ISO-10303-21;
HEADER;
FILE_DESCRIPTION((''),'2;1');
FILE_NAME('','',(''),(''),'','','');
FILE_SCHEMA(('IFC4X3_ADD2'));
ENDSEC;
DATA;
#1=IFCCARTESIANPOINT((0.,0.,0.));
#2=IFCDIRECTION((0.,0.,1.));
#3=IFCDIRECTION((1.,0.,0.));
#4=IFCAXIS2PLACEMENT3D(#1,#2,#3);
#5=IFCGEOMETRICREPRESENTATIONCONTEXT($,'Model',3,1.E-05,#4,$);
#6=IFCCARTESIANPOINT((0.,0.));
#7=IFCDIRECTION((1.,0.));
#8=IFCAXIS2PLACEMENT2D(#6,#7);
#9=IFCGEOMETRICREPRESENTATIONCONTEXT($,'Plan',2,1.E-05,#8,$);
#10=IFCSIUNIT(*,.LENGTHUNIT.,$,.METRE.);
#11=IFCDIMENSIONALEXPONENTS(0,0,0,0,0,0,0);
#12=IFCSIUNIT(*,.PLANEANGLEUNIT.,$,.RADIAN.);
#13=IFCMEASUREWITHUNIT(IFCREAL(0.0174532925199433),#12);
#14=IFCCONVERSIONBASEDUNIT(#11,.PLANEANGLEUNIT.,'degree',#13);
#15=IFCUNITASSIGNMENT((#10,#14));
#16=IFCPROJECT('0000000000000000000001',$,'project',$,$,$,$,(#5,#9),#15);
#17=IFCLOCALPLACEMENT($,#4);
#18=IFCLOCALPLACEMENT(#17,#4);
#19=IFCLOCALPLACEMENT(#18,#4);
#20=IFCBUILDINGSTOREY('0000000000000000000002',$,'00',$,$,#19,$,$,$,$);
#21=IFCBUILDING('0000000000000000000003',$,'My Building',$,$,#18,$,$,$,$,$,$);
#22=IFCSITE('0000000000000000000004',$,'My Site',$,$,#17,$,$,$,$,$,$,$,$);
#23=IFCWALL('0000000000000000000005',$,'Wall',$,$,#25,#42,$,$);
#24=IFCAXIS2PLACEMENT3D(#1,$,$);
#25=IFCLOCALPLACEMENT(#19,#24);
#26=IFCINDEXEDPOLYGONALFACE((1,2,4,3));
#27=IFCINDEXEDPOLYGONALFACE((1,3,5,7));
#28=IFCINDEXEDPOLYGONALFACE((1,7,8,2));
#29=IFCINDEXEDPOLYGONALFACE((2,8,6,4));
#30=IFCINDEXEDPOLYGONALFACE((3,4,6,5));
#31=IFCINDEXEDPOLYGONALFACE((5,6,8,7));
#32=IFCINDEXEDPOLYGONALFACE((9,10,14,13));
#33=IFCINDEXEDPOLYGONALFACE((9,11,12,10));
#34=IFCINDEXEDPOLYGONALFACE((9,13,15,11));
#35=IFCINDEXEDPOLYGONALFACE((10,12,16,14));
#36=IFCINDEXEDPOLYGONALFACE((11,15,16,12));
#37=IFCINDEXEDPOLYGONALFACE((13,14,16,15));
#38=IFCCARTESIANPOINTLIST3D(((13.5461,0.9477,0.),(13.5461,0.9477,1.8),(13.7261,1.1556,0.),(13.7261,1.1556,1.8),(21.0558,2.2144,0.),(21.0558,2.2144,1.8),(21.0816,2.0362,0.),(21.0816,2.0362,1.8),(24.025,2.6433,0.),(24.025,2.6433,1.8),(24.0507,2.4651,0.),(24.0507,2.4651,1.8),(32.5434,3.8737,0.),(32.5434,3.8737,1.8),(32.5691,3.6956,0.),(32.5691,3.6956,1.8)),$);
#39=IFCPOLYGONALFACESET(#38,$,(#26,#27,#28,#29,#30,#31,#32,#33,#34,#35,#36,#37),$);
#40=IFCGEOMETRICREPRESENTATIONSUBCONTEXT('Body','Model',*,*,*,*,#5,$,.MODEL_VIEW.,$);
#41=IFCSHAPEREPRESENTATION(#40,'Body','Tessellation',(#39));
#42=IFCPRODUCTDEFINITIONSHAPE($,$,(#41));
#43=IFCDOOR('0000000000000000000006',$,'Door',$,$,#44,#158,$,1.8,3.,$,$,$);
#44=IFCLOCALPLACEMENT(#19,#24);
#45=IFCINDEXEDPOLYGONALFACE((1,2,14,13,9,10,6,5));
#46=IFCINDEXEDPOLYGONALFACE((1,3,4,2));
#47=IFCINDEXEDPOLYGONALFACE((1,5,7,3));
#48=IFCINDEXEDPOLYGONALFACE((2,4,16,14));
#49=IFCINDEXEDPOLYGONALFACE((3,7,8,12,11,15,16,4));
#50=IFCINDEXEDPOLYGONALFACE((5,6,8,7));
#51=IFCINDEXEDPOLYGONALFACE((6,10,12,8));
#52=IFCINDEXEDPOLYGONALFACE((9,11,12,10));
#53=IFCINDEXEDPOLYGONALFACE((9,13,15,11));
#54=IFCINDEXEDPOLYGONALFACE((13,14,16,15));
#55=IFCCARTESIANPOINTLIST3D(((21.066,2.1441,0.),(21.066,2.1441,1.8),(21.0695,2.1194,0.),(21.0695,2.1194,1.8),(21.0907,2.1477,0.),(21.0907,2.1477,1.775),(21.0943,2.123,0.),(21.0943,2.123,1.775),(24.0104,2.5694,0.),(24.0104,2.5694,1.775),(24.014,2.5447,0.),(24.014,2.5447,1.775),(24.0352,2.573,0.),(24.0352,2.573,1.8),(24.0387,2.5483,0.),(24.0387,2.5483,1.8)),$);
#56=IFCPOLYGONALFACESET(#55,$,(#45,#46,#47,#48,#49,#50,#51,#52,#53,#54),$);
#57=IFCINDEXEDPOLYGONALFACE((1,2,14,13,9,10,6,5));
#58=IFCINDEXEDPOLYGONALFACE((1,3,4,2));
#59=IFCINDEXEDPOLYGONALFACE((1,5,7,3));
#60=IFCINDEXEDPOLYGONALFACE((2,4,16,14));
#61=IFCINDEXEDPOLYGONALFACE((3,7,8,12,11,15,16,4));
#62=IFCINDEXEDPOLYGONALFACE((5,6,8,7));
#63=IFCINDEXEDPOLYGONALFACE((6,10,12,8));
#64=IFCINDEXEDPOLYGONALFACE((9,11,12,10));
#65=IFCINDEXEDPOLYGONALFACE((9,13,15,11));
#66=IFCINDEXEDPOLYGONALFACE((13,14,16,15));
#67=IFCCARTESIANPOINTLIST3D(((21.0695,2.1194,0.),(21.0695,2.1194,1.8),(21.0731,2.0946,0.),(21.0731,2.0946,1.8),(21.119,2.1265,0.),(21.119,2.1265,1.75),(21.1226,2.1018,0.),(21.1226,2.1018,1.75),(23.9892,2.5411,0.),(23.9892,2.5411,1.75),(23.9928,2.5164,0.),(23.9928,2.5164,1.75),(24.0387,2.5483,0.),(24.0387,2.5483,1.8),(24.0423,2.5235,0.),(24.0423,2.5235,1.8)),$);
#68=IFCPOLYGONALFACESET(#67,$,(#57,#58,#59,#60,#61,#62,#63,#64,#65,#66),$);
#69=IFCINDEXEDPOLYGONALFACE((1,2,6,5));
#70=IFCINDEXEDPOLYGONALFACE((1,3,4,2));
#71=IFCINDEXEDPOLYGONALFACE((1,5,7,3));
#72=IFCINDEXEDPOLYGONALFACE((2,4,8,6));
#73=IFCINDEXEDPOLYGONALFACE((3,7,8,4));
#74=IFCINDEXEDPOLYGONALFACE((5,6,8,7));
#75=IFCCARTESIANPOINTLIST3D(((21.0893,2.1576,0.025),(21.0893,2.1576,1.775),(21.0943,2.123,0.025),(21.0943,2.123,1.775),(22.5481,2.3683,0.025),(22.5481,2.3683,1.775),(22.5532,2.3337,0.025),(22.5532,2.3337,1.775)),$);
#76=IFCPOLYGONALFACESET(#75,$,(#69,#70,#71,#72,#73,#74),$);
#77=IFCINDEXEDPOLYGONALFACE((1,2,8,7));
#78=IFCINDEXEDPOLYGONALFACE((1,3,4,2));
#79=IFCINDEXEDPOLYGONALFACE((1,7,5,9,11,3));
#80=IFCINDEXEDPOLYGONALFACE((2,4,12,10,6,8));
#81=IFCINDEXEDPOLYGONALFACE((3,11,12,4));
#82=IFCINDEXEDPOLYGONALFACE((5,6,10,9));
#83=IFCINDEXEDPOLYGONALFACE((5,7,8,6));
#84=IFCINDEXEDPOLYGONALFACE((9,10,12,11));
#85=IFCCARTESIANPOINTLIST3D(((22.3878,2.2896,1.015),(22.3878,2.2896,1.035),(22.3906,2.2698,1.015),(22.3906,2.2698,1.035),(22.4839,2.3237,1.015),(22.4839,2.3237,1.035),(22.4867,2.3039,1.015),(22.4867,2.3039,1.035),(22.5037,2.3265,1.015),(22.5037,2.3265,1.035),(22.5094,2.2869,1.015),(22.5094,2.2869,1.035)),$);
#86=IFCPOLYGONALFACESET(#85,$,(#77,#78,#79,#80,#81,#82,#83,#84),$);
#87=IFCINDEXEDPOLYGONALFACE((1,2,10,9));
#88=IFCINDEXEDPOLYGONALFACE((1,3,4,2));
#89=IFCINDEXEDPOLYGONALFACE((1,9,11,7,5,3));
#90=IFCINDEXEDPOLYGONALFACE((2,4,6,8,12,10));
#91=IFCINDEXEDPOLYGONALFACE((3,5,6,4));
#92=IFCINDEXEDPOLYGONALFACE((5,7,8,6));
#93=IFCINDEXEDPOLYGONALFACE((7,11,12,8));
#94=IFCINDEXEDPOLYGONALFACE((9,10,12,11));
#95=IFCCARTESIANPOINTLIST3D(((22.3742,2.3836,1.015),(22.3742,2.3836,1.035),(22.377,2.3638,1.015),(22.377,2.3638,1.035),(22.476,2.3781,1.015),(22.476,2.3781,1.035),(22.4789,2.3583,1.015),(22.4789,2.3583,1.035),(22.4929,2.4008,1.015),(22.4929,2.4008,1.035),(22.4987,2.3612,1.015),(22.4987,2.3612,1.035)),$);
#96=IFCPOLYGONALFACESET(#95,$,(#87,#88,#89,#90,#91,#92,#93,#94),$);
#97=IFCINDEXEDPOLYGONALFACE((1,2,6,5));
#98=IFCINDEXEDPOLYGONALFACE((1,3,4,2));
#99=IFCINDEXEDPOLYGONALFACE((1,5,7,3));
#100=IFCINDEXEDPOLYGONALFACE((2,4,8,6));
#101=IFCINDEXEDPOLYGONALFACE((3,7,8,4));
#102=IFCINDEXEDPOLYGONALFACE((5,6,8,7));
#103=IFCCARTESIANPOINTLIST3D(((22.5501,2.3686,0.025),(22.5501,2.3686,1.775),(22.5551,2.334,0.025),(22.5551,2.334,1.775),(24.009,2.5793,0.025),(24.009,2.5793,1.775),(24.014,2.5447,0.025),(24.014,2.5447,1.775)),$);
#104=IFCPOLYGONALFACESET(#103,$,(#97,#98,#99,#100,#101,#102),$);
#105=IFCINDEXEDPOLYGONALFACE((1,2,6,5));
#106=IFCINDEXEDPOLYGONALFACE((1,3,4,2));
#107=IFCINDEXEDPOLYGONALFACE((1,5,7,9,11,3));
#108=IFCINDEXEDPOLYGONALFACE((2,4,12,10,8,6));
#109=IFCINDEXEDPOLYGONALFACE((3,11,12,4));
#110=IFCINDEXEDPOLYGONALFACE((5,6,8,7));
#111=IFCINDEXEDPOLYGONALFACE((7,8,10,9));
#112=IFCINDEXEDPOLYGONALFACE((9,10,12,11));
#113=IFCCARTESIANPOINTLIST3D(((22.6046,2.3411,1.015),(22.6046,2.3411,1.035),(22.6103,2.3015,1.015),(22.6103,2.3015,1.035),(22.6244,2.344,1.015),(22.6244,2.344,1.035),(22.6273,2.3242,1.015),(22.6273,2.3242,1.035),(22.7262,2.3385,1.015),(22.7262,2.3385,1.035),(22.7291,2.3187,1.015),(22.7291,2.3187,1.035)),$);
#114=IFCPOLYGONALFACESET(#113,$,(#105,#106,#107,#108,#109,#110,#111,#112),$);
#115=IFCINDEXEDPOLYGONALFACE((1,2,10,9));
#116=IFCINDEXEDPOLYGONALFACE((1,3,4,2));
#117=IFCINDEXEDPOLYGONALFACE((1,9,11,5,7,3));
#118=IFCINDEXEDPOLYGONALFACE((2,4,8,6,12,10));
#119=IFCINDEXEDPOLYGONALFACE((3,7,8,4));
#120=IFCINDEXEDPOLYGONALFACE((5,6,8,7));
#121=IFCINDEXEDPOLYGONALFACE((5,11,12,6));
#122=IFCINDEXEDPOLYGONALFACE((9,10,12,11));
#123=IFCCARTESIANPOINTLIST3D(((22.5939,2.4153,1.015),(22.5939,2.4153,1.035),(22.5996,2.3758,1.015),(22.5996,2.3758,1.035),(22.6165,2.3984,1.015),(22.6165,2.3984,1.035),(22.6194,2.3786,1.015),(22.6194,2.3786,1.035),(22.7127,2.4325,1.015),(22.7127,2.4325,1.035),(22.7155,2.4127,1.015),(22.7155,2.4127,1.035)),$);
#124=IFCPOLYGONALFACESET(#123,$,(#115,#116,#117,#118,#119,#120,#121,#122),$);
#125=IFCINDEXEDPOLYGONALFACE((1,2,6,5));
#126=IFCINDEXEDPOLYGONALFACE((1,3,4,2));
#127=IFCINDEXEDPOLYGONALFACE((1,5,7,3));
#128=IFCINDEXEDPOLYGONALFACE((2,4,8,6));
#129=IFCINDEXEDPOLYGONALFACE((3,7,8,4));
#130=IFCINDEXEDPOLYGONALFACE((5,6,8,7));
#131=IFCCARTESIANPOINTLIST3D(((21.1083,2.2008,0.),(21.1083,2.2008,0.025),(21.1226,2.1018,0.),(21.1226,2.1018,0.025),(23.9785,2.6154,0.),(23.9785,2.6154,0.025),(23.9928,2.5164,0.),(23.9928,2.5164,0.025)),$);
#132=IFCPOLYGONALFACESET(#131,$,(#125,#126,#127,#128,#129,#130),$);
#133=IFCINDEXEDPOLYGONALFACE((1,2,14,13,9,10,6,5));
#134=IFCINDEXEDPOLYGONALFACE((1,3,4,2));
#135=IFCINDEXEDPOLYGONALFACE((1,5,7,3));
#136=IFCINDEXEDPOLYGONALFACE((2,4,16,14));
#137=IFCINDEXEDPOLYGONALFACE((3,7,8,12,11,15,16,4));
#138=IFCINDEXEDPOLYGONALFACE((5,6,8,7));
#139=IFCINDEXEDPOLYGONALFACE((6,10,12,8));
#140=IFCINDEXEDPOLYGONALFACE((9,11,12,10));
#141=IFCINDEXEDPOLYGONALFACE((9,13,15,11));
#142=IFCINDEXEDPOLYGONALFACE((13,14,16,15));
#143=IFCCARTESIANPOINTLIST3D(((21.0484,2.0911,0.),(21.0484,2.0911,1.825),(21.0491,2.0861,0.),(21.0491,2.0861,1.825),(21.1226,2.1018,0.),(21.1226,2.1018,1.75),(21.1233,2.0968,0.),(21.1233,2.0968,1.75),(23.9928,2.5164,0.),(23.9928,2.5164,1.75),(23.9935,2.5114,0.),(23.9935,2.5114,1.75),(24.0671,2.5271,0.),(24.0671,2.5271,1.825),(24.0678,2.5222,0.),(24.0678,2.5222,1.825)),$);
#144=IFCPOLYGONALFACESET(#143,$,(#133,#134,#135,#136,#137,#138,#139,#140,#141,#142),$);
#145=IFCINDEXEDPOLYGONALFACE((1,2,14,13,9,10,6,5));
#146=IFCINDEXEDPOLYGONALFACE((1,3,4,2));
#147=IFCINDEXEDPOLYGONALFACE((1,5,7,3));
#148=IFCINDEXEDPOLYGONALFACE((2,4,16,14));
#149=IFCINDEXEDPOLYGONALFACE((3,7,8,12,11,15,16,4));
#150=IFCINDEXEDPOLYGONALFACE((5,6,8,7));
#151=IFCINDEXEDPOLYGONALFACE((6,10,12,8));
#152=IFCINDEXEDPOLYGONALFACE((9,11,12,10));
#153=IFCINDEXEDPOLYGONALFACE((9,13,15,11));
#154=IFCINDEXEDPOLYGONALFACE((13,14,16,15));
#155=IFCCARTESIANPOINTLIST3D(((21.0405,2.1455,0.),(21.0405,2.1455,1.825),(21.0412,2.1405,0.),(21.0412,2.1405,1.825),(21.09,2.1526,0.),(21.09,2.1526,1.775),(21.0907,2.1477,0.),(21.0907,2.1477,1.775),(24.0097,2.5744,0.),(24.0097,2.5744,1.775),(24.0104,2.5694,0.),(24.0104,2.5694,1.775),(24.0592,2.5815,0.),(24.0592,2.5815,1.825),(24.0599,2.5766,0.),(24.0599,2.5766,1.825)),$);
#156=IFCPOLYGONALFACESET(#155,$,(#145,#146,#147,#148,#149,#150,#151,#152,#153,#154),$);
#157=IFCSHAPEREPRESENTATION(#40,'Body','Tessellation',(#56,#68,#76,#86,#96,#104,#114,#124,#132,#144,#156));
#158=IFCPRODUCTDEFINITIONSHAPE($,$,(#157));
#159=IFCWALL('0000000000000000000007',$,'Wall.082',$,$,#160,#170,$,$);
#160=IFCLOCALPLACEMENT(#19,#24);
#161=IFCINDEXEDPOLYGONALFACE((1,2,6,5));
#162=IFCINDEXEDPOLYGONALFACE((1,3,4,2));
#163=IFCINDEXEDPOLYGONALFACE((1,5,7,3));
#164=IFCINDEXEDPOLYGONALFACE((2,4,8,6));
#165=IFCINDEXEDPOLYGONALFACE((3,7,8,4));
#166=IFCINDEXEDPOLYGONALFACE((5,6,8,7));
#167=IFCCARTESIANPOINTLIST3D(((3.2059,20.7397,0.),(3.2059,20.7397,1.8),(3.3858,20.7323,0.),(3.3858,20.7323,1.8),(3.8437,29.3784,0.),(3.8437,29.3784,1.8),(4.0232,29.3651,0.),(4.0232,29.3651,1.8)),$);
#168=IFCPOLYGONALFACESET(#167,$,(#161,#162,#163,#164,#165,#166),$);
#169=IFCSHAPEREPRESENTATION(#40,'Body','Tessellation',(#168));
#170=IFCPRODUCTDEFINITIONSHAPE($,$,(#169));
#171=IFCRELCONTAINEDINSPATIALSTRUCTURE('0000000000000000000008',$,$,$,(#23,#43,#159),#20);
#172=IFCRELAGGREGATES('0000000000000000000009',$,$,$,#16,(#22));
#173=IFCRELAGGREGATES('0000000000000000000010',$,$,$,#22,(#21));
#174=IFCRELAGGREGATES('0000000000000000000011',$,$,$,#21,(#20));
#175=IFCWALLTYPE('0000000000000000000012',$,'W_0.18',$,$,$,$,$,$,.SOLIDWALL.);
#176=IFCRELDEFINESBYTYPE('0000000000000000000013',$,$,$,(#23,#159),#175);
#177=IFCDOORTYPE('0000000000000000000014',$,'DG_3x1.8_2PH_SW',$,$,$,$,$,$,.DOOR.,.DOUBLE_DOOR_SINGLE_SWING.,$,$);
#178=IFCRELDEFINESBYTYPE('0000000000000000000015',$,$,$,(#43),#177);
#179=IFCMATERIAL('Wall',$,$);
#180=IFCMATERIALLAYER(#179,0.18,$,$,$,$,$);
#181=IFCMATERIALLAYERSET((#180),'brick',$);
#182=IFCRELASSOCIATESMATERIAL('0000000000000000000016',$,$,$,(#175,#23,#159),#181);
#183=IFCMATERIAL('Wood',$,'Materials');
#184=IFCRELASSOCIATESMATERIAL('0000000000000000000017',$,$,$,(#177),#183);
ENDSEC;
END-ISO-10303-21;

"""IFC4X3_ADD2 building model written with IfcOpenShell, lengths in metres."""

from ifc_helpers import new_model, entity, si_unit, converted_unit, frame, origin_with_axes, origin_2d_with_axis, place, context, subcontext, project, spatial, line, indexed_curve, outline, extrude, shape, source, transform, mapped, material, layer, layer_set, layer_usage, type_object, type_shapes, element, fill, save


model = new_model("IFC4X3_ADD2")

# Units and contexts
model_context = context("Model", 3, precision=1e-05, world=origin_with_axes())
plan_context = context("Plan", 2, precision=1e-05, world=origin_2d_with_axis())
body_context_1 = subcontext(model_context, "Body", "Model", "MODEL_VIEW")
body_context_2 = subcontext(plan_context, "Body", "Plan", "PLAN_VIEW")
ifc_project = project(units=[si_unit("LENGTHUNIT", "METRE"), converted_unit("PLANEANGLEUNIT", "degree", entity("IfcReal", 0.0174532925199433), si_unit("PLANEANGLEUNIT", "RADIAN"), dimensions=[0, 0, 0, 0, 0, 0, 0])], contexts=[model_context, plan_context])

# Site, building, storey
site_placement = place(None, origin_with_axes())
site = spatial("IfcSite", under=ifc_project, at=site_placement, Name="My Site")
building_placement = place(site_placement, origin_with_axes())
building = spatial("IfcBuilding", under=site, at=building_placement, Name="My Building")
storey_placement = place(building_placement, origin_with_axes())
storey = spatial("IfcBuildingStorey", under=building, at=storey_placement, Name="00")

# Shared definitions
ifc_material_1 = material(Name="Wall")
ifc_layer_1 = layer(ifc_material_1, 0.18)
ifc_layer_set_1 = layer_set([ifc_layer_1], Name="brick")
wall_type_1 = type_object("IfcWallType", Name="W_0.18", PredefinedType="SOLIDWALL", material=ifc_layer_set_1)

# Wall, opening, door
ifc_layer_usage_1 = layer_usage(ifc_layer_set_1, "AXIS2", "POSITIVE", 0.0)
wall_1_placement = place(storey_placement, frame((13.7261, 0.9737, 0.0), z_axis=(0.0, 0.0, 1.0), x_axis=(0.989728, 0.142965, 0.0)))
wall_1 = element("IfcWall", 1, at=wall_1_placement, inside=storey, type_object=wall_type_1, material=ifc_layer_usage_1, Name="Wall", context=body_context_1, shape_type="SweptSolid", body=[
    extrude(outline(indexed_curve([(-0.1819, 0.0), (0.026, 0.18), (19.0386, 0.18), (19.0386, 0.0)], segments=[line(1, 2, 3, 4, 1)])), origin_with_axes(), (0.0, 0.0, 1.0), 1.8),
])
shared_shape_1 = source(origin_with_axes(), body_context_1, "Body", "SweptSolid", [
    extrude(outline(indexed_curve([(0.0, 0.0), (3.0, 0.0), (3.0, 1.8), (0.0, 1.8)], segments=[line(1, 2, 3, 4, 1)])), frame((0.0, -0.6, 0.0), z_axis=(0.0, -1.0, 0.0), x_axis=(1.0, 0.0, 0.0)), (0.0, 0.0, -1.0), 1.2),
])
opening_1_placement = place(wall_1_placement, frame((7.4318, 0.059, 0.0), z_axis=(0.0, 0.0, 1.0), x_axis=(1.0, 0.0, 0.0)))
opening_1 = element("IfcOpeningElement", 2, at=opening_1_placement, cuts=wall_1, PredefinedType="OPENING", context=body_context_1, shape_type="MappedRepresentation", body=[
    mapped(shared_shape_1, transform((0.0, 0.0, 0.0), x_axis=(1.0, 0.0, 0.0), y_axis=(0.0, 1.0, 0.0), z_axis=(0.0, 0.0, 1.0), scale=1.0)),
])
ifc_material_2 = material(Name="Wood", Category="Materials")
door_type_1 = type_object("IfcDoorType", Name="DG_3x1.8_2PH_SW", OperationType="DOUBLE_DOOR_SINGLE_SWING", PredefinedType="DOOR", material=ifc_material_2)
shared_shape_2 = source(origin_with_axes(), body_context_1, "Body", "SweptSolid", [
    extrude(outline(indexed_curve([(0.0, 0.0), (0.0, 1.8), (3.0, 1.8), (3.0, 0.0), (2.975, 0.0), (2.975, 1.775), (0.025, 1.775), (0.025, 0.0)], segments=[line(1, 2, 3, 4, 5, 6, 7, 8, 1)])), frame((0.0, 0.025, 0.0), z_axis=(0.0, -1.0, 0.0), x_axis=(1.0, 0.0, 0.0)), (0.0, 0.0, -1.0), 0.025),
    extrude(outline(indexed_curve([(0.0, 0.0), (0.0, 1.8), (3.0, 1.8), (3.0, 0.0), (2.95, 0.0), (2.95, 1.75), (0.05, 1.75), (0.05, 0.0)], segments=[line(1, 2, 3, 4, 5, 6, 7, 8, 1)])), frame((0.0, 0.0, 0.0), z_axis=(0.0, -1.0, 0.0), x_axis=(1.0, 0.0, 0.0)), (0.0, 0.0, -1.0), 0.025),
    extrude(outline(indexed_curve([(0.0, 0.0), (1.474, 0.0), (1.474, 0.035), (0.0, 0.035)], segments=[line(1, 2, 3, 4, 1)])), frame((0.025, 0.025, 0.025), z_axis=(0.0, 0.0, 1.0), x_axis=(1.0, 0.0, 0.0)), (0.0, 0.0, 1.0), 1.75),
    extrude(outline(indexed_curve([(0.0, 0.0), (0.0, -0.04), (-0.12, -0.04), (-0.12, -0.02), (-0.02, -0.02), (-0.02, 0.0)], segments=[line(1, 2, 3, 4, 5, 6, 1)])), frame((1.449, 0.025, 1.015), z_axis=(0.0, 0.0, 1.0), x_axis=(1.0, 0.0, 0.0)), (0.0, 0.0, 1.0), 0.02),
    extrude(outline(indexed_curve([(0.0, 0.0), (0.0, 0.04), (-0.12, 0.04), (-0.12, 0.02), (-0.02, 0.02), (-0.02, 0.0)], segments=[line(1, 2, 3, 4, 5, 6, 1)])), frame((1.449, 0.06, 1.015), z_axis=(0.0, 0.0, 1.0), x_axis=(1.0, 0.0, 0.0)), (0.0, 0.0, 1.0), 0.02),
    extrude(outline(indexed_curve([(0.0, 0.0), (-1.474, 0.0), (-1.474, 0.035), (0.0, 0.035)], segments=[line(1, 2, 3, 4, 1)])), frame((2.975, 0.025, 0.025), z_axis=(0.0, 0.0, 1.0), x_axis=(1.0, 0.0, 0.0)), (0.0, 0.0, 1.0), 1.75),
    extrude(outline(indexed_curve([(0.0, 0.0), (0.0, -0.04), (0.12, -0.04), (0.12, -0.02), (0.02, -0.02), (0.02, 0.0)], segments=[line(1, 2, 3, 4, 5, 6, 1)])), frame((1.551, 0.025, 1.015), z_axis=(0.0, 0.0, 1.0), x_axis=(1.0, 0.0, 0.0)), (0.0, 0.0, 1.0), 0.02),
    extrude(outline(indexed_curve([(0.0, 0.0), (0.0, 0.04), (0.12, 0.04), (0.12, 0.02), (0.02, 0.02), (0.02, 0.0)], segments=[line(1, 2, 3, 4, 5, 6, 1)])), frame((1.551, 0.06, 1.015), z_axis=(0.0, 0.0, 1.0), x_axis=(1.0, 0.0, 0.0)), (0.0, 0.0, 1.0), 0.02),
    extrude(outline(indexed_curve([(0.0, 0.0), (2.9, 0.0), (2.9, 0.1), (0.0, 0.1)], segments=[line(1, 2, 3, 4, 1)])), frame((0.05, 0.0, 0.0), z_axis=(0.0, 0.0, 1.0), x_axis=(1.0, 0.0, 0.0)), (0.0, 0.0, 1.0), 0.025),
    extrude(outline(indexed_curve([(0.0, 0.0), (0.0, 1.825), (3.05, 1.825), (3.05, 0.0), (2.975, 0.0), (2.975, 1.75), (0.075, 1.75), (0.075, 0.0)], segments=[line(1, 2, 3, 4, 5, 6, 7, 8, 1)])), frame((-0.025, -0.005, 0.0), z_axis=(0.0, -1.0, 0.0), x_axis=(1.0, 0.0, 0.0)), (0.0, 0.0, -1.0), 0.005),
    extrude(outline(indexed_curve([(0.0, 0.0), (0.0, 1.825), (3.05, 1.825), (3.05, 0.0), (3.0, 0.0), (3.0, 1.775), (0.05, 1.775), (0.05, 0.0)], segments=[line(1, 2, 3, 4, 5, 6, 7, 8, 1)])), frame((-0.025, 0.05, 0.0), z_axis=(0.0, -1.0, 0.0), x_axis=(1.0, 0.0, 0.0)), (0.0, 0.0, -1.0), 0.005),
])
shared_shape_3 = source(origin_with_axes(), body_context_2, "Body", "Curve2D", [
    entity("IfcIndexedPolyCurve", entity("IfcCartesianPointList2D", [[0.0, 0.0], [0.0, 0.05], [0.025, 0.05], [0.025, 0.025], [0.05, 0.025], [0.05, 0.0]]), [entity("IfcLineIndex", [1, 2, 3, 4, 5, 6, 1])]),
    entity("IfcIndexedPolyCurve", entity("IfcCartesianPointList2D", [[3.0, 0.0], [3.0, 0.05], [2.975, 0.05], [2.975, 0.025], [2.95, 0.025], [2.95, 0.0]]), [entity("IfcLineIndex", [1, 2, 3, 4, 5, 6, 1])]),
    entity("IfcTrimmedCurve", entity("IfcEllipse", entity("IfcAxis2Placement2D", entity("IfcCartesianPoint", [0.06, 0.05]), entity("IfcDirection", [1.0, 0.0])), 1.44, 1.475), [entity("IfcCartesianPoint", [1.5, 0.05])], [entity("IfcCartesianPoint", [0.06, 1.525])], True, "CARTESIAN"),
    entity("IfcIndexedPolyCurve", entity("IfcCartesianPointList2D", [[0.025, 0.05], [0.06, 0.05], [0.06, 1.525], [0.025, 1.525]]), [entity("IfcLineIndex", [1, 2, 3, 4, 1])]),
    entity("IfcTrimmedCurve", entity("IfcEllipse", entity("IfcAxis2Placement2D", entity("IfcCartesianPoint", [2.94, 0.05]), entity("IfcDirection", [1.0, 0.0])), 1.44, 1.475), [entity("IfcCartesianPoint", [2.94, 1.525])], [entity("IfcCartesianPoint", [1.5, 0.05])], True, "CARTESIAN"),
    entity("IfcIndexedPolyCurve", entity("IfcCartesianPointList2D", [[2.975, 0.05], [2.94, 0.05], [2.94, 1.525], [2.975, 1.525]]), [entity("IfcLineIndex", [1, 2, 3, 4, 1])]),
])
type_shapes(door_type_1, [shared_shape_2, shared_shape_3])
door_1_placement = place(opening_1_placement, frame((0.0, 0.0, 0.0), z_axis=(0.0, 0.0, 1.0), x_axis=(1.0, 0.0, 0.0)))
door_1 = element("IfcDoor", 3, at=door_1_placement, inside=storey, type_object=door_type_1, Name="Door", OverallHeight=1.8, OverallWidth=3.0, shapes=[
    shape(body_context_1, "Body", "MappedRepresentation", [mapped(shared_shape_2, transform((0.0, 0.0, 0.0), x_axis=(1.0, 0.0, 0.0), y_axis=(0.0, 1.0, 0.0), z_axis=(0.0, 0.0, 1.0), scale=1.0))]),
    shape(body_context_2, "Body", "MappedRepresentation", [mapped(shared_shape_3, transform((0.0, 0.0, 0.0), x_axis=(1.0, 0.0, 0.0), y_axis=(0.0, 1.0, 0.0), z_axis=(0.0, 0.0, 1.0), scale=1.0))]),
])
fill(opening_1, door_1)

# Wall
ifc_layer_usage_2 = layer_usage(ifc_layer_set_1, "AXIS2", "POSITIVE", 0.0)
wall_2_placement = place(storey_placement, frame((3.8437, 29.3784, 0.0), z_axis=(0.0, 0.0, 1.0), x_axis=(-0.073632, -0.997286, 0.0)))
element("IfcWall", 4, at=wall_2_placement, inside=storey, type_object=wall_type_1, material=ifc_layer_usage_2, Name="Wall.082", context=body_context_1, shape_type="SweptSolid", body=[
    extrude(outline(indexed_curve([(0.0, 0.0), (0.0, 0.18), (8.6563, 0.18), (8.6622, 0.0)], segments=[line(1, 2, 3, 4, 1)])), origin_with_axes(), (0.0, 0.0, 1.0), 1.8),
])

save(model, "model.ifc")
